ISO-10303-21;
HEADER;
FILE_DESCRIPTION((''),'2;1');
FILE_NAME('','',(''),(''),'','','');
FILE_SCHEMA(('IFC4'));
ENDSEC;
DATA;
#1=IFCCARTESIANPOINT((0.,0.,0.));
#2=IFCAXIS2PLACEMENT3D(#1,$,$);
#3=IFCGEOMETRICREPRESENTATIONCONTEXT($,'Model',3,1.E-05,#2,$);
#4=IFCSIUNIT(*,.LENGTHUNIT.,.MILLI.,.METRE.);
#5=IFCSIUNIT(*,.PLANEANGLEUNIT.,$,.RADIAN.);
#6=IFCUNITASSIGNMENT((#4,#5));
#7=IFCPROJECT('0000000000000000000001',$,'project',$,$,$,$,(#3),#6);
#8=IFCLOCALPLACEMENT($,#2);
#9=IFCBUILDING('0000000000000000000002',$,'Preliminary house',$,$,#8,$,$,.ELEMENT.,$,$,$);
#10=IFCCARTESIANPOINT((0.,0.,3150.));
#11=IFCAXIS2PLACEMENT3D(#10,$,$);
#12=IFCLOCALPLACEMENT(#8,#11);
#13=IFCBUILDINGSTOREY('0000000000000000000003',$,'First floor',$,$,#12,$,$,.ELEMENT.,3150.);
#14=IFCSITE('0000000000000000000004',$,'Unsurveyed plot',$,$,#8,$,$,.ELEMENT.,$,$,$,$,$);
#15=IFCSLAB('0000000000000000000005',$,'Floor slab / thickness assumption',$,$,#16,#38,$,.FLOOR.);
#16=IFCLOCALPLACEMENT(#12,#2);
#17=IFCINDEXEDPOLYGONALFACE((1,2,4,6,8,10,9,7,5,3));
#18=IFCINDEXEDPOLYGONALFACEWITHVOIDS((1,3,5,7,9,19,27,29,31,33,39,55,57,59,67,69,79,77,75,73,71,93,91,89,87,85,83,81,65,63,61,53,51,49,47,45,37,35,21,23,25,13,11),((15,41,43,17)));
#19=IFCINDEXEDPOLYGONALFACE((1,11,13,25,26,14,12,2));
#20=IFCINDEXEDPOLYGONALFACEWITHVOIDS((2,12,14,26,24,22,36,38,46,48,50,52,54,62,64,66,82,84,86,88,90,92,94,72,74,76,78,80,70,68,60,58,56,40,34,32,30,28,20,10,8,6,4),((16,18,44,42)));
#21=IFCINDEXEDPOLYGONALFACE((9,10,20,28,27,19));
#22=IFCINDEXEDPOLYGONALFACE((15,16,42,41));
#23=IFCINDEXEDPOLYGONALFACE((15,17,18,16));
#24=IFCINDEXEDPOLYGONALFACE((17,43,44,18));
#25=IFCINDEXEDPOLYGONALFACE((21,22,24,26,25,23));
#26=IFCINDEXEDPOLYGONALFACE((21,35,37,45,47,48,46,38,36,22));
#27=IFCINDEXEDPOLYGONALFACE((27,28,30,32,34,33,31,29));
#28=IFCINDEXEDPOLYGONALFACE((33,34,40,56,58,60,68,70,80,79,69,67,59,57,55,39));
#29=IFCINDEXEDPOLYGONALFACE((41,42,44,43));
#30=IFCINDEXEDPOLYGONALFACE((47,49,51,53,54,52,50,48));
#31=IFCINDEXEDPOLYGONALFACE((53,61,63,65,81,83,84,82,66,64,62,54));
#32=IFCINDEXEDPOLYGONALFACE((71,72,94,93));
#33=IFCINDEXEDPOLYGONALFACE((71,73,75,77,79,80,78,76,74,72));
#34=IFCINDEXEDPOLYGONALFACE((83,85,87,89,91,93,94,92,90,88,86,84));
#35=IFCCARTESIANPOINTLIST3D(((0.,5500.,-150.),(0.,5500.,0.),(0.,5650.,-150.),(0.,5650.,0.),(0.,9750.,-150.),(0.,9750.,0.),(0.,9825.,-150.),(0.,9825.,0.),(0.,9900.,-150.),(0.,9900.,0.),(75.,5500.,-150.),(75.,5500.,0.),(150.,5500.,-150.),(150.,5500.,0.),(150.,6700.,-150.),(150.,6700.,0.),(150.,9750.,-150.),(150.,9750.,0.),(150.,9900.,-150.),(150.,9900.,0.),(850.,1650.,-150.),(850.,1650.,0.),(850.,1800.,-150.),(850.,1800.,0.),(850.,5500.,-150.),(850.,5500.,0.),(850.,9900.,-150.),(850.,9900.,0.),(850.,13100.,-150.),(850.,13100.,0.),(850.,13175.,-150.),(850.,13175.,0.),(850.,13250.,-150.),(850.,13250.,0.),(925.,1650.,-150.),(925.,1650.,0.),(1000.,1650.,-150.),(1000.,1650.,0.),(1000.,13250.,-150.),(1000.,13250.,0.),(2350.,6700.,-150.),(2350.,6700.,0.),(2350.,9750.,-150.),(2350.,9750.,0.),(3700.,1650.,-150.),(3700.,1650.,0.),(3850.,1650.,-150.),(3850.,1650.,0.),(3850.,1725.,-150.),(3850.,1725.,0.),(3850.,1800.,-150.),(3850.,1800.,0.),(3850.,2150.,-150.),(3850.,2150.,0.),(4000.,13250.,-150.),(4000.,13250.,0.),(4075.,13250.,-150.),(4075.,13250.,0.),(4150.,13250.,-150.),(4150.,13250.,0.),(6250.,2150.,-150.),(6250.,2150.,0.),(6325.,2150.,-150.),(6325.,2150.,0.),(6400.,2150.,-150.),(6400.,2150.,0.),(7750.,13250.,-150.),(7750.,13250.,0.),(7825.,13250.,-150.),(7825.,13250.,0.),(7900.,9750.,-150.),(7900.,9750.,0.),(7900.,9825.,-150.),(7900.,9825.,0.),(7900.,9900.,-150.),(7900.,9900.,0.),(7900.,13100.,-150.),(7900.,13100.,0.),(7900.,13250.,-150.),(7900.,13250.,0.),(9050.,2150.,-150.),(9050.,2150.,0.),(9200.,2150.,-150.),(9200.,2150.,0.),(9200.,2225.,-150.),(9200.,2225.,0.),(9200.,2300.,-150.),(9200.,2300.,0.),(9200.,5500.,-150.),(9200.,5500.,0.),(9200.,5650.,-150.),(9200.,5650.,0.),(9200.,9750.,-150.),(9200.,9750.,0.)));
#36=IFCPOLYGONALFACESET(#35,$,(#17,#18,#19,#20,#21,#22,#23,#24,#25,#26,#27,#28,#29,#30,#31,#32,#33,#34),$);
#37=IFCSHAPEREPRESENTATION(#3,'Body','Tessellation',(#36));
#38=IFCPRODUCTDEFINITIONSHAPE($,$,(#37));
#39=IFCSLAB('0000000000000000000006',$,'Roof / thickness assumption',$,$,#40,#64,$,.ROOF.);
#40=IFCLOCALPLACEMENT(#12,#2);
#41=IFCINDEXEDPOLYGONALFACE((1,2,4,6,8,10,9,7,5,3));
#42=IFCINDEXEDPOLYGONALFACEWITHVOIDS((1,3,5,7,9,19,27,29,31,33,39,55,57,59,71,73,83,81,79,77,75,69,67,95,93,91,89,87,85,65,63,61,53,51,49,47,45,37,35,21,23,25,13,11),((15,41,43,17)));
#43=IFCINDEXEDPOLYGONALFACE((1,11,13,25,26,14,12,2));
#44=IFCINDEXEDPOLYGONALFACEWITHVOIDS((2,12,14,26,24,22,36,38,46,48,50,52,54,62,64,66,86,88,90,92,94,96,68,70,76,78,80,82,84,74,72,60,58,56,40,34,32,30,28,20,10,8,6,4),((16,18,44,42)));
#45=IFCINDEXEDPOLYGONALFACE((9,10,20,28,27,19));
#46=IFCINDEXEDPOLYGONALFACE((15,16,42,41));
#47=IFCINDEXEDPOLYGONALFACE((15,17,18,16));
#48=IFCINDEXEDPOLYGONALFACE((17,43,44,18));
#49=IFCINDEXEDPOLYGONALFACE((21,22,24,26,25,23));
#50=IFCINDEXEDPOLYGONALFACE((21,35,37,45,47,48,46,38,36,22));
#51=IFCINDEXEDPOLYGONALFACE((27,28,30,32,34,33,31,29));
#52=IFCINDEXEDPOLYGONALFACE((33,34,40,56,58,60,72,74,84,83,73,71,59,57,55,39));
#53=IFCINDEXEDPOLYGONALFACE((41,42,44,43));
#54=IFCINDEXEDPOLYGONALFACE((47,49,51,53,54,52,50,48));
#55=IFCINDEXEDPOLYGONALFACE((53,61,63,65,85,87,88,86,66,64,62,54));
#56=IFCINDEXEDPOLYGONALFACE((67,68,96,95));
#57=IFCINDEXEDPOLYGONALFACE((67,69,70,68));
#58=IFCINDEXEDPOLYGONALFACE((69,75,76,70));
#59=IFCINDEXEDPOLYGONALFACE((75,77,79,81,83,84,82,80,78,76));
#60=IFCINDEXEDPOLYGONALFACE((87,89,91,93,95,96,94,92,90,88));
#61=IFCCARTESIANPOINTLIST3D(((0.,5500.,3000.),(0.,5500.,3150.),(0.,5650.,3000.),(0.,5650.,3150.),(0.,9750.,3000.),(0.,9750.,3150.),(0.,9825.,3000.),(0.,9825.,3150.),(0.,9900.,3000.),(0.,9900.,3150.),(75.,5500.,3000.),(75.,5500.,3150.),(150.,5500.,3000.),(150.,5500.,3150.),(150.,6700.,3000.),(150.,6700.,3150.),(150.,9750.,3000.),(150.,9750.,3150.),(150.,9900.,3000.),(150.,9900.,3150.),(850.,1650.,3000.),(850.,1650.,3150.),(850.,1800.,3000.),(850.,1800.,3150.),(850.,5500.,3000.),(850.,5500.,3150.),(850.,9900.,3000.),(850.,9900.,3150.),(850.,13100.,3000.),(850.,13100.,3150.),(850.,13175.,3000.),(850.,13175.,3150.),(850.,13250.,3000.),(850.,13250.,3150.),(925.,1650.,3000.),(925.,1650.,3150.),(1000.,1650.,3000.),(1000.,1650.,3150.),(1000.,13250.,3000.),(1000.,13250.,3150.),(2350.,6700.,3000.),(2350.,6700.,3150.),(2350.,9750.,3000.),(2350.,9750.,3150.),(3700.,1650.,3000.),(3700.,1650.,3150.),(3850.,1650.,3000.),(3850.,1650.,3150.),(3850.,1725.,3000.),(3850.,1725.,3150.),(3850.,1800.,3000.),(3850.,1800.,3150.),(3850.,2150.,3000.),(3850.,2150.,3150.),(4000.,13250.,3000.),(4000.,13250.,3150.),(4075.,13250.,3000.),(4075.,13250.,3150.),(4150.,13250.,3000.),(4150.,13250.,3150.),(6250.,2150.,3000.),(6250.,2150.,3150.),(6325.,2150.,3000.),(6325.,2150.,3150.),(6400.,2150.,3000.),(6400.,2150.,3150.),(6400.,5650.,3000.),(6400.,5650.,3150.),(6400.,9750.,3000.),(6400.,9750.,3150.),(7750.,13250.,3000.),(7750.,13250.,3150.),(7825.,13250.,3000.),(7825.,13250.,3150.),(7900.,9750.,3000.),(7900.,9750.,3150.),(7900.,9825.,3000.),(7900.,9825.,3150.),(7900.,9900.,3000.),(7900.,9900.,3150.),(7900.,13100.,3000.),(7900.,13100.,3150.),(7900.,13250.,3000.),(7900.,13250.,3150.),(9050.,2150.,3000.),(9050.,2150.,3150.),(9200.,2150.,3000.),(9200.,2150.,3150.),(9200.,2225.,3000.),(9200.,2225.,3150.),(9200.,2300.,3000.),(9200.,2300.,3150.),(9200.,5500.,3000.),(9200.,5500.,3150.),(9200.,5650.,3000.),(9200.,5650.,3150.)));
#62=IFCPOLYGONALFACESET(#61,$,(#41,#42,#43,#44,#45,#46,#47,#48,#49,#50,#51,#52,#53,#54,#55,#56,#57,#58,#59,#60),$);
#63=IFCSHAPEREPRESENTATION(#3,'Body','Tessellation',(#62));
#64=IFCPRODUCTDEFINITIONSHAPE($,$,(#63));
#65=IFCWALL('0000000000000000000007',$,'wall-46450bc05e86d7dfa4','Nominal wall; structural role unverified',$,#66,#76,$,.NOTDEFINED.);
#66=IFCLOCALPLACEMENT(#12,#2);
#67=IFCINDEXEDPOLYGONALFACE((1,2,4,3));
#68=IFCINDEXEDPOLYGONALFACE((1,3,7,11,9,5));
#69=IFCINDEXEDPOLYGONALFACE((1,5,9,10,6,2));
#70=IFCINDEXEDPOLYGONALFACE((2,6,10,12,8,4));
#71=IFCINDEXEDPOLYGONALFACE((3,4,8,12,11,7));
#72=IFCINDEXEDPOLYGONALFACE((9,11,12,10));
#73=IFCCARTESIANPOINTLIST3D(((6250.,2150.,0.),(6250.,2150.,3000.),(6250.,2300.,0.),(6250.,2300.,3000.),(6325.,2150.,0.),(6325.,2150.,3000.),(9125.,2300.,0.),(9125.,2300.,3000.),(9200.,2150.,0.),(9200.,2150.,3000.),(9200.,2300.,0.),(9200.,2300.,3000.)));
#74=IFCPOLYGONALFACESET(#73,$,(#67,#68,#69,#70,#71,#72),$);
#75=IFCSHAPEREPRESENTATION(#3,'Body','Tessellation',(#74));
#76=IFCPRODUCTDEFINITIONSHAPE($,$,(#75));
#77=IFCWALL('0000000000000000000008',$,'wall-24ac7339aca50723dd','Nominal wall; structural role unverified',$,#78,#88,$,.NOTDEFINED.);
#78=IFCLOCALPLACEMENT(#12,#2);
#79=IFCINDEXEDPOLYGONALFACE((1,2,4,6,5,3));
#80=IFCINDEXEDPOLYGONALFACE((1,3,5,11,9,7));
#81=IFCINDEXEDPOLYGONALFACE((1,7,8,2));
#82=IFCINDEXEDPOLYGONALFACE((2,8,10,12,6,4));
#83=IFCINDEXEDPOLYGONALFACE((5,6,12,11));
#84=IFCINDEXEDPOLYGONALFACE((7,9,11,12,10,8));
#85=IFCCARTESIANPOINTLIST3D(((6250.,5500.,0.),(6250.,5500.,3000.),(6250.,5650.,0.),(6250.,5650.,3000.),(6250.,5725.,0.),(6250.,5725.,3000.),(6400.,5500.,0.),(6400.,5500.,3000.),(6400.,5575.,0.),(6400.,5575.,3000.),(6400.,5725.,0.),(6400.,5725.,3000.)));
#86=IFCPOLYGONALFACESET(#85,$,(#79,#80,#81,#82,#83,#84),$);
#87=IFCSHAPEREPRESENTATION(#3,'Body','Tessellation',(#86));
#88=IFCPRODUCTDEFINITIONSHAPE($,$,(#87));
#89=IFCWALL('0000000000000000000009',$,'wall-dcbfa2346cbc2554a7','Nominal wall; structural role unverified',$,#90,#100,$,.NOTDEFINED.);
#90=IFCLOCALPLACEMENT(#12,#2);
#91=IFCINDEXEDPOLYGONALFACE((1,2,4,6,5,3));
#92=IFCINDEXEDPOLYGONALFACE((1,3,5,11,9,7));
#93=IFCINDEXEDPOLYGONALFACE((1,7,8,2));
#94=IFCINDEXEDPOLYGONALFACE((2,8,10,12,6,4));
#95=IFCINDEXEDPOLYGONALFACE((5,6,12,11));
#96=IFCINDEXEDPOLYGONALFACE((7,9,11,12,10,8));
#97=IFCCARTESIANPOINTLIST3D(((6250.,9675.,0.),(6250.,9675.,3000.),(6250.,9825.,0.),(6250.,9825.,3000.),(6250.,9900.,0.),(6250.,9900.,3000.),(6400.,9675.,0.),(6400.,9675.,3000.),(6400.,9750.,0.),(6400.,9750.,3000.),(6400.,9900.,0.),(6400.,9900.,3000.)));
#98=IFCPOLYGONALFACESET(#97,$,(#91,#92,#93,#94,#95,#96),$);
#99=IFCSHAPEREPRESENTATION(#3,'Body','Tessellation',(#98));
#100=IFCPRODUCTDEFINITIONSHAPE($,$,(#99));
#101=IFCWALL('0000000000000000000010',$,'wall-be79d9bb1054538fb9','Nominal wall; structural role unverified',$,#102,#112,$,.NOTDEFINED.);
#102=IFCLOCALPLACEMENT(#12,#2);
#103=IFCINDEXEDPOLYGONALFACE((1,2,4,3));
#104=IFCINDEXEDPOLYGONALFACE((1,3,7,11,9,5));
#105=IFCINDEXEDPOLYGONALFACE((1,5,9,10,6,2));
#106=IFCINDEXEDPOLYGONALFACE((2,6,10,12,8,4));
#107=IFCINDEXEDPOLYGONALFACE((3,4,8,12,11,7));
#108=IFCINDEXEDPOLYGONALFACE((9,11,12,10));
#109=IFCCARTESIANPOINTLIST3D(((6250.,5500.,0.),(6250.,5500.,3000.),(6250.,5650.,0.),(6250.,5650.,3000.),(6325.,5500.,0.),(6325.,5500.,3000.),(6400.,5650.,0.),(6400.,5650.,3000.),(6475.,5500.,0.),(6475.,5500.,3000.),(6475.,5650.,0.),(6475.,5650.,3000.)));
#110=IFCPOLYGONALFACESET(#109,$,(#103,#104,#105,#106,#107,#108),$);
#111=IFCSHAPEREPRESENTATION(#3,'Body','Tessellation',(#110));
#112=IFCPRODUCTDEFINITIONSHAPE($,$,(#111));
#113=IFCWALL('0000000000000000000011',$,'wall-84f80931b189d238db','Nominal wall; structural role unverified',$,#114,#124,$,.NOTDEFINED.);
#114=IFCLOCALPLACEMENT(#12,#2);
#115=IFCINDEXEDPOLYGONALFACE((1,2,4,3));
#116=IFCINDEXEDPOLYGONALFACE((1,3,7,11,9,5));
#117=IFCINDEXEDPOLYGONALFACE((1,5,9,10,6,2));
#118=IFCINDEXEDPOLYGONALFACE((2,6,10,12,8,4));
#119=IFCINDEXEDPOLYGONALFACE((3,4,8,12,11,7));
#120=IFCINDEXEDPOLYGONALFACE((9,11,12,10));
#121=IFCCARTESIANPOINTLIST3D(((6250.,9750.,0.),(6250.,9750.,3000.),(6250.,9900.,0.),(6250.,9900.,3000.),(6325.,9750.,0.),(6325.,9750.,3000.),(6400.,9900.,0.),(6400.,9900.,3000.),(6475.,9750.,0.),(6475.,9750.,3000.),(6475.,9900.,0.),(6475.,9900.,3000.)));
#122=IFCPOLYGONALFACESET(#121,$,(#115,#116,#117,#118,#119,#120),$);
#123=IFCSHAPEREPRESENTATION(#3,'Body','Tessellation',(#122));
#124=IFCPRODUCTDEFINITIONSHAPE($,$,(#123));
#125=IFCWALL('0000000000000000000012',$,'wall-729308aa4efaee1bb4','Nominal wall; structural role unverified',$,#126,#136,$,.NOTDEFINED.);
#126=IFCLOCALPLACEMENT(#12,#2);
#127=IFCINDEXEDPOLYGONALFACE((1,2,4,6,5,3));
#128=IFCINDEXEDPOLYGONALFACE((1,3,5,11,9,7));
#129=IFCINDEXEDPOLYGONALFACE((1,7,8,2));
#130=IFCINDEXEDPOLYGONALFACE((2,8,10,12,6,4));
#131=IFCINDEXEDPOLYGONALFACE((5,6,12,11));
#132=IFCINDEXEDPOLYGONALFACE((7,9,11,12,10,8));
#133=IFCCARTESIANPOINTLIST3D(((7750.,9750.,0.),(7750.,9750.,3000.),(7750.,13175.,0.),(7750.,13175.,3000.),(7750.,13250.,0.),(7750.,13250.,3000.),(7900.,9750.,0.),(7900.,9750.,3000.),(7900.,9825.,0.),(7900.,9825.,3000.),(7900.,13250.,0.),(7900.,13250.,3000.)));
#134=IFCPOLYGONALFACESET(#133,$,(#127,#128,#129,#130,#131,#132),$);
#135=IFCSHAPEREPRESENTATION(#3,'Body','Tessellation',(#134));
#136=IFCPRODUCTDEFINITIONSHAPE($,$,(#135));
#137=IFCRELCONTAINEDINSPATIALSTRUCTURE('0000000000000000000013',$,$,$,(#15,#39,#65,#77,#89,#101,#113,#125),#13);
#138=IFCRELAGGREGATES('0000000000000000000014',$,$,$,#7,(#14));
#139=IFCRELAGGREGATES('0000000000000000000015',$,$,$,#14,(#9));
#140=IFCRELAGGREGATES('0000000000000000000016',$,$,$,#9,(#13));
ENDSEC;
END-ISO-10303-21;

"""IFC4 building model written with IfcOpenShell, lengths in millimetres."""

from ifc_helpers import new_model, si_unit, frame, origin, place, context, project, spatial, polyline, outline, extrude, element, save


model = new_model("IFC4")

# Units and contexts
model_context = context("Model", 3, precision=1e-05, world=origin())
ifc_project = project(units=[si_unit("LENGTHUNIT", "METRE", prefix="MILLI"), si_unit("PLANEANGLEUNIT", "RADIAN")], contexts=[model_context])

# Site, building, storey
placement_1 = place(None, origin())
site = spatial("IfcSite", under=ifc_project, at=placement_1, Name="Unsurveyed plot", CompositionType="ELEMENT")
building = spatial("IfcBuilding", under=site, at=placement_1, Name="Preliminary house", CompositionType="ELEMENT")
placement_2 = place(placement_1, frame((0.0, 0.0, 3150.0)))
storey = spatial("IfcBuildingStorey", under=building, at=placement_2, Name="First floor", CompositionType="ELEMENT", Elevation=3150.0)

# Slabs
element("IfcSlab", 1, at=placement_2, inside=storey, Name="Floor slab / thickness assumption", PredefinedType="FLOOR", context=model_context, shape_type="SweptSolid", body=[
    extrude(outline(polyline([(850.0, 1650.0), (850.0, 1800.0), (850.0, 5500.0), (150.0, 5500.0), (75.0, 5500.0), (0.0, 5500.0), (0.0, 5650.0), (0.0, 9750.0), (0.0, 9825.0), (0.0, 9900.0), (150.0, 9900.0), (850.0, 9900.0), (850.0, 13100.0), (850.0, 13175.0), (850.0, 13250.0), (1000.0, 13250.0), (4000.0, 13250.0), (4075.0, 13250.0), (4150.0, 13250.0), (7750.0, 13250.0), (7825.0, 13250.0), (7900.0, 13250.0), (7900.0, 13100.0), (7900.0, 9900.0), (7900.0, 9825.0), (7900.0, 9750.0), (9200.0, 9750.0), (9200.0, 5650.0), (9200.0, 5500.0), (9200.0, 2300.0), (9200.0, 2225.0), (9200.0, 2150.0), (9050.0, 2150.0), (6400.0, 2150.0), (6325.0, 2150.0), (6250.0, 2150.0), (3850.0, 2150.0), (3850.0, 1800.0), (3850.0, 1725.0), (3850.0, 1650.0), (3700.0, 1650.0), (1000.0, 1650.0), (925.0, 1650.0), (850.0, 1650.0)]), holes=[polyline([(2350.0, 9750.0), (150.0, 9750.0), (150.0, 6700.0), (2350.0, 6700.0), (2350.0, 9750.0)])]), frame((0.0, 0.0, -150.0)), (0.0, 0.0, 1.0), 150.0),
])
element("IfcSlab", 2, at=placement_2, inside=storey, Name="Roof / thickness assumption", PredefinedType="ROOF", context=model_context, shape_type="SweptSolid", body=[
    extrude(outline(polyline([(850.0, 1800.0), (850.0, 5500.0), (150.0, 5500.0), (75.0, 5500.0), (0.0, 5500.0), (0.0, 5650.0), (0.0, 9750.0), (0.0, 9825.0), (0.0, 9900.0), (150.0, 9900.0), (850.0, 9900.0), (850.0, 13100.0), (850.0, 13175.0), (850.0, 13250.0), (1000.0, 13250.0), (4000.0, 13250.0), (4075.0, 13250.0), (4150.0, 13250.0), (7750.0, 13250.0), (7825.0, 13250.0), (7900.0, 13250.0), (7900.0, 13100.0), (7900.0, 9900.0), (7900.0, 9825.0), (7900.0, 9750.0), (6400.0, 9750.0), (6400.0, 5650.0), (9200.0, 5650.0), (9200.0, 5500.0), (9200.0, 2300.0), (9200.0, 2225.0), (9200.0, 2150.0), (9050.0, 2150.0), (6400.0, 2150.0), (6325.0, 2150.0), (6250.0, 2150.0), (3850.0, 2150.0), (3850.0, 1800.0), (3850.0, 1725.0), (3850.0, 1650.0), (3700.0, 1650.0), (1000.0, 1650.0), (925.0, 1650.0), (850.0, 1650.0), (850.0, 1800.0)]), holes=[polyline([(2350.0, 9750.0), (150.0, 9750.0), (150.0, 6700.0), (2350.0, 6700.0), (2350.0, 9750.0)])]), frame((0.0, 0.0, 3000.0)), (0.0, 0.0, 1.0), 150.0),
])

# Walls
element("IfcWall", 3, at=placement_2, inside=storey, Name="wall-46450bc05e86d7dfa4", Description="Nominal wall; structural role unverified", PredefinedType="NOTDEFINED", context=model_context, shape_type="SweptSolid", body=[
    extrude(outline(polyline([(9125.0, 2300.0), (9200.0, 2300.0), (9200.0, 2150.0), (6325.0, 2150.0), (6250.0, 2150.0), (6250.0, 2300.0), (9125.0, 2300.0)])), origin(), (0.0, 0.0, 1.0), 3000.0),
])
element("IfcWall", 4, at=placement_2, inside=storey, Name="wall-24ac7339aca50723dd", Description="Nominal wall; structural role unverified", PredefinedType="NOTDEFINED", context=model_context, shape_type="SweptSolid", body=[
    extrude(outline(polyline([(6250.0, 5650.0), (6250.0, 5725.0), (6400.0, 5725.0), (6400.0, 5575.0), (6400.0, 5500.0), (6250.0, 5500.0), (6250.0, 5650.0)])), origin(), (0.0, 0.0, 1.0), 3000.0),
])

# Walls
element("IfcWall", 5, at=placement_2, inside=storey, Name="wall-dcbfa2346cbc2554a7", Description="Nominal wall; structural role unverified", PredefinedType="NOTDEFINED", context=model_context, shape_type="SweptSolid", body=[
    extrude(outline(polyline([(6250.0, 9825.0), (6250.0, 9900.0), (6400.0, 9900.0), (6400.0, 9750.0), (6400.0, 9675.0), (6250.0, 9675.0), (6250.0, 9825.0)])), origin(), (0.0, 0.0, 1.0), 3000.0),
])
element("IfcWall", 6, at=placement_2, inside=storey, Name="wall-be79d9bb1054538fb9", Description="Nominal wall; structural role unverified", PredefinedType="NOTDEFINED", context=model_context, shape_type="SweptSolid", body=[
    extrude(outline(polyline([(6400.0, 5650.0), (6475.0, 5650.0), (6475.0, 5500.0), (6325.0, 5500.0), (6250.0, 5500.0), (6250.0, 5650.0), (6400.0, 5650.0)])), origin(), (0.0, 0.0, 1.0), 3000.0),
])

# Wall
element("IfcWall", 7, at=placement_2, inside=storey, Name="wall-84f80931b189d238db", Description="Nominal wall; structural role unverified", PredefinedType="NOTDEFINED", context=model_context, shape_type="SweptSolid", body=[
    extrude(outline(polyline([(6400.0, 9900.0), (6475.0, 9900.0), (6475.0, 9750.0), (6325.0, 9750.0), (6250.0, 9750.0), (6250.0, 9900.0), (6400.0, 9900.0)])), origin(), (0.0, 0.0, 1.0), 3000.0),
])

# Wall
element("IfcWall", 8, at=placement_2, inside=storey, Name="wall-729308aa4efaee1bb4", Description="Nominal wall; structural role unverified", PredefinedType="NOTDEFINED", context=model_context, shape_type="SweptSolid", body=[
    extrude(outline(polyline([(7750.0, 13175.0), (7750.0, 13250.0), (7900.0, 13250.0), (7900.0, 9825.0), (7900.0, 9750.0), (7750.0, 9750.0), (7750.0, 13175.0)])), origin(), (0.0, 0.0, 1.0), 3000.0),
])

save(model, "model.ifc")
